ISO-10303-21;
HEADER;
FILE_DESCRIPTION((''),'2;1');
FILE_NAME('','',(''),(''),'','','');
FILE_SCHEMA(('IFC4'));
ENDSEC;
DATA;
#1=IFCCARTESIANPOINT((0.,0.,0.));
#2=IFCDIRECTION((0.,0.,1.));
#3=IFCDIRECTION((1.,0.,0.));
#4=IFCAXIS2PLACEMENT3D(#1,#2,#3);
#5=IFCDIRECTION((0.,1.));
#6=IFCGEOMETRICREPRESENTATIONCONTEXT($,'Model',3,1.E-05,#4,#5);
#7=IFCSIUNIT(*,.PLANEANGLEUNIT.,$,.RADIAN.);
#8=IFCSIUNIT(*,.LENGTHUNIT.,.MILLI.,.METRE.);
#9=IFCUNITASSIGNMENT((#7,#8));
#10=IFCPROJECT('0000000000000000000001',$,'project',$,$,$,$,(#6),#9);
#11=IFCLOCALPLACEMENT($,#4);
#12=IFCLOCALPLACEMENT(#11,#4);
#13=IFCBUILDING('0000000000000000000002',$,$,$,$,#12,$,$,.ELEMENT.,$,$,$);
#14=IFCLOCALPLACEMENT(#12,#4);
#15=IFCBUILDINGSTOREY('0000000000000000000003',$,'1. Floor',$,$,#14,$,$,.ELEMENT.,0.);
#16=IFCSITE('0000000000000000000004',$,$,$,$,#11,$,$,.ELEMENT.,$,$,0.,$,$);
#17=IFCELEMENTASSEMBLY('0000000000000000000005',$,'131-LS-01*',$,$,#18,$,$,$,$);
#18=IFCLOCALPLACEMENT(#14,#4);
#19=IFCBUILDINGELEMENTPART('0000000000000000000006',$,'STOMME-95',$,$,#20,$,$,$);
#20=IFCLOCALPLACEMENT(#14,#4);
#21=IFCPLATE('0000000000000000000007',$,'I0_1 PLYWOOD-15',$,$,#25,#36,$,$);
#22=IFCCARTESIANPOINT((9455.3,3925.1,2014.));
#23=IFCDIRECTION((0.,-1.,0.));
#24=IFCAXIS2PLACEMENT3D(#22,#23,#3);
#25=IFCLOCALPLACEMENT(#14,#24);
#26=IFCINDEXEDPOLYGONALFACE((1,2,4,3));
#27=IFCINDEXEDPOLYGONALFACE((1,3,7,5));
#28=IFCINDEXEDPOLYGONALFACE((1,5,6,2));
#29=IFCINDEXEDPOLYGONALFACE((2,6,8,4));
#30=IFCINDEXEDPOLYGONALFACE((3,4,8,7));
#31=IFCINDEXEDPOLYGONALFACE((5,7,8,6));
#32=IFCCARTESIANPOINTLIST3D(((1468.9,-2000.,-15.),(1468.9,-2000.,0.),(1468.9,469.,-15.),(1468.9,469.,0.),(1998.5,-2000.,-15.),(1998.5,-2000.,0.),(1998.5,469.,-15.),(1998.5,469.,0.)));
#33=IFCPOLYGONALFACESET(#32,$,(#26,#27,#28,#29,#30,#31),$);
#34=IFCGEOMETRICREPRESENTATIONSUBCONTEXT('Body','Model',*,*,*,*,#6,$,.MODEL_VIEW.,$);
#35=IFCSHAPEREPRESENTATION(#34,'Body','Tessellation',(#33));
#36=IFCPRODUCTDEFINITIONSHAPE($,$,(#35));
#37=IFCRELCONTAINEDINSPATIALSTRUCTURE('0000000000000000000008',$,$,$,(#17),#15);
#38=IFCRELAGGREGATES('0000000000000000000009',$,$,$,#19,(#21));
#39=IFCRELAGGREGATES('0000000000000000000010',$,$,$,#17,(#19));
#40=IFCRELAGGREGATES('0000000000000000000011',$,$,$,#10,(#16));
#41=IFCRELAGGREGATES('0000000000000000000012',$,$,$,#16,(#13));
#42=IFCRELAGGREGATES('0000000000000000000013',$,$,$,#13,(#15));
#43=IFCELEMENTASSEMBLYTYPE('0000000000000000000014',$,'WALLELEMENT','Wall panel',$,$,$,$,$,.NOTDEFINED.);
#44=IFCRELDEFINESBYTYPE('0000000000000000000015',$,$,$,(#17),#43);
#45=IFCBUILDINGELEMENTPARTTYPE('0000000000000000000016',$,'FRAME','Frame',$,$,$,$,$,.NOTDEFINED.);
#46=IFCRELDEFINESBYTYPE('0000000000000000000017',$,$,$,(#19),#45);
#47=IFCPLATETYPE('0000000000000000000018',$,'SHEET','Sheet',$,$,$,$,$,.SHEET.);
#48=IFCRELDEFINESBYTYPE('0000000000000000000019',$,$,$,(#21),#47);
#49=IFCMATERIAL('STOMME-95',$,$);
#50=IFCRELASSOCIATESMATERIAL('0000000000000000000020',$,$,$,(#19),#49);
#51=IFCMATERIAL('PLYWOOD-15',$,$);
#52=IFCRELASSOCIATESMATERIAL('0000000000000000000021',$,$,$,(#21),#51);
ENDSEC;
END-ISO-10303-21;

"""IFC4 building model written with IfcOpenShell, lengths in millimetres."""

from ifc_helpers import new_model, si_unit, direction, frame, origin_with_axes, origin_2d_with_axis, place, context, subcontext, project, spatial, rectangle, extrude, material, type_object, element, aggregate, save


model = new_model("IFC4")

# Units and contexts
model_context = context("Model", 3, precision=1e-05, world=origin_with_axes(), true_north=direction((0.0, 1.0)))
body_context = subcontext(model_context, "Body", "Model", "MODEL_VIEW")
ifc_project = project(units=[si_unit("PLANEANGLEUNIT", "RADIAN"), si_unit("LENGTHUNIT", "METRE", prefix="MILLI")], contexts=[model_context])

# Site, building, storey
site_placement = place(None, origin_with_axes())
site = spatial("IfcSite", under=ifc_project, at=site_placement, CompositionType="ELEMENT", RefElevation=0.0)
building_placement = place(site_placement, origin_with_axes())
building = spatial("IfcBuilding", under=site, at=building_placement, CompositionType="ELEMENT")
storey_placement = place(building_placement, origin_with_axes())
storey = spatial("IfcBuildingStorey", under=building, at=storey_placement, Name="1. Floor", CompositionType="ELEMENT", Elevation=0.0)

# Element assembly, building element part
element_assembly_type_1 = type_object("IfcElementAssemblyType", Name="WALLELEMENT", Description="Wall panel", PredefinedType="NOTDEFINED")
assembly_1_placement = place(storey_placement, origin_with_axes())
assembly_1 = element("IfcElementAssembly", 1, at=assembly_1_placement, inside=storey, type_object=element_assembly_type_1, Name="131-LS-01*")
ifc_material_1 = material(Name="STOMME-95")
building_element_part_type = type_object("IfcBuildingElementPartType", Name="FRAME", Description="Frame", PredefinedType="NOTDEFINED")
building_element_part_1_placement = place(storey_placement, origin_with_axes())
building_element_part_1 = element("IfcBuildingElementPart", 2, at=building_element_part_1_placement, type_object=building_element_part_type, material=ifc_material_1, Name="STOMME-95")

# Plate
ifc_material_2 = material(Name="PLYWOOD-15")
plate_type_1 = type_object("IfcPlateType", Name="SHEET", Description="Sheet", PredefinedType="SHEET")
plate_1_placement = place(storey_placement, frame((9455.3, 3925.1, 2014.0), z_axis=(0.0, -1.0, 0.0), x_axis=(1.0, 0.0, 0.0)))
plate_1 = element("IfcPlate", 3, at=plate_1_placement, type_object=plate_type_1, material=ifc_material_2, Name="I0_1 PLYWOOD-15", context=body_context, shape_type="SweptSolid", body=[
    extrude(rectangle(XDim=15.0, YDim=529.6, at=origin_2d_with_axis()), frame((1733.7, -2000.0, -7.5), z_axis=(0.0, 1.0, 0.0), x_axis=(0.0, 0.0, 1.0)), (0.0, 0.0, 1.0), 2469.0),
])
aggregate(building_element_part_1, [plate_1])

aggregate(assembly_1, [building_element_part_1])

save(model, "model.ifc")
